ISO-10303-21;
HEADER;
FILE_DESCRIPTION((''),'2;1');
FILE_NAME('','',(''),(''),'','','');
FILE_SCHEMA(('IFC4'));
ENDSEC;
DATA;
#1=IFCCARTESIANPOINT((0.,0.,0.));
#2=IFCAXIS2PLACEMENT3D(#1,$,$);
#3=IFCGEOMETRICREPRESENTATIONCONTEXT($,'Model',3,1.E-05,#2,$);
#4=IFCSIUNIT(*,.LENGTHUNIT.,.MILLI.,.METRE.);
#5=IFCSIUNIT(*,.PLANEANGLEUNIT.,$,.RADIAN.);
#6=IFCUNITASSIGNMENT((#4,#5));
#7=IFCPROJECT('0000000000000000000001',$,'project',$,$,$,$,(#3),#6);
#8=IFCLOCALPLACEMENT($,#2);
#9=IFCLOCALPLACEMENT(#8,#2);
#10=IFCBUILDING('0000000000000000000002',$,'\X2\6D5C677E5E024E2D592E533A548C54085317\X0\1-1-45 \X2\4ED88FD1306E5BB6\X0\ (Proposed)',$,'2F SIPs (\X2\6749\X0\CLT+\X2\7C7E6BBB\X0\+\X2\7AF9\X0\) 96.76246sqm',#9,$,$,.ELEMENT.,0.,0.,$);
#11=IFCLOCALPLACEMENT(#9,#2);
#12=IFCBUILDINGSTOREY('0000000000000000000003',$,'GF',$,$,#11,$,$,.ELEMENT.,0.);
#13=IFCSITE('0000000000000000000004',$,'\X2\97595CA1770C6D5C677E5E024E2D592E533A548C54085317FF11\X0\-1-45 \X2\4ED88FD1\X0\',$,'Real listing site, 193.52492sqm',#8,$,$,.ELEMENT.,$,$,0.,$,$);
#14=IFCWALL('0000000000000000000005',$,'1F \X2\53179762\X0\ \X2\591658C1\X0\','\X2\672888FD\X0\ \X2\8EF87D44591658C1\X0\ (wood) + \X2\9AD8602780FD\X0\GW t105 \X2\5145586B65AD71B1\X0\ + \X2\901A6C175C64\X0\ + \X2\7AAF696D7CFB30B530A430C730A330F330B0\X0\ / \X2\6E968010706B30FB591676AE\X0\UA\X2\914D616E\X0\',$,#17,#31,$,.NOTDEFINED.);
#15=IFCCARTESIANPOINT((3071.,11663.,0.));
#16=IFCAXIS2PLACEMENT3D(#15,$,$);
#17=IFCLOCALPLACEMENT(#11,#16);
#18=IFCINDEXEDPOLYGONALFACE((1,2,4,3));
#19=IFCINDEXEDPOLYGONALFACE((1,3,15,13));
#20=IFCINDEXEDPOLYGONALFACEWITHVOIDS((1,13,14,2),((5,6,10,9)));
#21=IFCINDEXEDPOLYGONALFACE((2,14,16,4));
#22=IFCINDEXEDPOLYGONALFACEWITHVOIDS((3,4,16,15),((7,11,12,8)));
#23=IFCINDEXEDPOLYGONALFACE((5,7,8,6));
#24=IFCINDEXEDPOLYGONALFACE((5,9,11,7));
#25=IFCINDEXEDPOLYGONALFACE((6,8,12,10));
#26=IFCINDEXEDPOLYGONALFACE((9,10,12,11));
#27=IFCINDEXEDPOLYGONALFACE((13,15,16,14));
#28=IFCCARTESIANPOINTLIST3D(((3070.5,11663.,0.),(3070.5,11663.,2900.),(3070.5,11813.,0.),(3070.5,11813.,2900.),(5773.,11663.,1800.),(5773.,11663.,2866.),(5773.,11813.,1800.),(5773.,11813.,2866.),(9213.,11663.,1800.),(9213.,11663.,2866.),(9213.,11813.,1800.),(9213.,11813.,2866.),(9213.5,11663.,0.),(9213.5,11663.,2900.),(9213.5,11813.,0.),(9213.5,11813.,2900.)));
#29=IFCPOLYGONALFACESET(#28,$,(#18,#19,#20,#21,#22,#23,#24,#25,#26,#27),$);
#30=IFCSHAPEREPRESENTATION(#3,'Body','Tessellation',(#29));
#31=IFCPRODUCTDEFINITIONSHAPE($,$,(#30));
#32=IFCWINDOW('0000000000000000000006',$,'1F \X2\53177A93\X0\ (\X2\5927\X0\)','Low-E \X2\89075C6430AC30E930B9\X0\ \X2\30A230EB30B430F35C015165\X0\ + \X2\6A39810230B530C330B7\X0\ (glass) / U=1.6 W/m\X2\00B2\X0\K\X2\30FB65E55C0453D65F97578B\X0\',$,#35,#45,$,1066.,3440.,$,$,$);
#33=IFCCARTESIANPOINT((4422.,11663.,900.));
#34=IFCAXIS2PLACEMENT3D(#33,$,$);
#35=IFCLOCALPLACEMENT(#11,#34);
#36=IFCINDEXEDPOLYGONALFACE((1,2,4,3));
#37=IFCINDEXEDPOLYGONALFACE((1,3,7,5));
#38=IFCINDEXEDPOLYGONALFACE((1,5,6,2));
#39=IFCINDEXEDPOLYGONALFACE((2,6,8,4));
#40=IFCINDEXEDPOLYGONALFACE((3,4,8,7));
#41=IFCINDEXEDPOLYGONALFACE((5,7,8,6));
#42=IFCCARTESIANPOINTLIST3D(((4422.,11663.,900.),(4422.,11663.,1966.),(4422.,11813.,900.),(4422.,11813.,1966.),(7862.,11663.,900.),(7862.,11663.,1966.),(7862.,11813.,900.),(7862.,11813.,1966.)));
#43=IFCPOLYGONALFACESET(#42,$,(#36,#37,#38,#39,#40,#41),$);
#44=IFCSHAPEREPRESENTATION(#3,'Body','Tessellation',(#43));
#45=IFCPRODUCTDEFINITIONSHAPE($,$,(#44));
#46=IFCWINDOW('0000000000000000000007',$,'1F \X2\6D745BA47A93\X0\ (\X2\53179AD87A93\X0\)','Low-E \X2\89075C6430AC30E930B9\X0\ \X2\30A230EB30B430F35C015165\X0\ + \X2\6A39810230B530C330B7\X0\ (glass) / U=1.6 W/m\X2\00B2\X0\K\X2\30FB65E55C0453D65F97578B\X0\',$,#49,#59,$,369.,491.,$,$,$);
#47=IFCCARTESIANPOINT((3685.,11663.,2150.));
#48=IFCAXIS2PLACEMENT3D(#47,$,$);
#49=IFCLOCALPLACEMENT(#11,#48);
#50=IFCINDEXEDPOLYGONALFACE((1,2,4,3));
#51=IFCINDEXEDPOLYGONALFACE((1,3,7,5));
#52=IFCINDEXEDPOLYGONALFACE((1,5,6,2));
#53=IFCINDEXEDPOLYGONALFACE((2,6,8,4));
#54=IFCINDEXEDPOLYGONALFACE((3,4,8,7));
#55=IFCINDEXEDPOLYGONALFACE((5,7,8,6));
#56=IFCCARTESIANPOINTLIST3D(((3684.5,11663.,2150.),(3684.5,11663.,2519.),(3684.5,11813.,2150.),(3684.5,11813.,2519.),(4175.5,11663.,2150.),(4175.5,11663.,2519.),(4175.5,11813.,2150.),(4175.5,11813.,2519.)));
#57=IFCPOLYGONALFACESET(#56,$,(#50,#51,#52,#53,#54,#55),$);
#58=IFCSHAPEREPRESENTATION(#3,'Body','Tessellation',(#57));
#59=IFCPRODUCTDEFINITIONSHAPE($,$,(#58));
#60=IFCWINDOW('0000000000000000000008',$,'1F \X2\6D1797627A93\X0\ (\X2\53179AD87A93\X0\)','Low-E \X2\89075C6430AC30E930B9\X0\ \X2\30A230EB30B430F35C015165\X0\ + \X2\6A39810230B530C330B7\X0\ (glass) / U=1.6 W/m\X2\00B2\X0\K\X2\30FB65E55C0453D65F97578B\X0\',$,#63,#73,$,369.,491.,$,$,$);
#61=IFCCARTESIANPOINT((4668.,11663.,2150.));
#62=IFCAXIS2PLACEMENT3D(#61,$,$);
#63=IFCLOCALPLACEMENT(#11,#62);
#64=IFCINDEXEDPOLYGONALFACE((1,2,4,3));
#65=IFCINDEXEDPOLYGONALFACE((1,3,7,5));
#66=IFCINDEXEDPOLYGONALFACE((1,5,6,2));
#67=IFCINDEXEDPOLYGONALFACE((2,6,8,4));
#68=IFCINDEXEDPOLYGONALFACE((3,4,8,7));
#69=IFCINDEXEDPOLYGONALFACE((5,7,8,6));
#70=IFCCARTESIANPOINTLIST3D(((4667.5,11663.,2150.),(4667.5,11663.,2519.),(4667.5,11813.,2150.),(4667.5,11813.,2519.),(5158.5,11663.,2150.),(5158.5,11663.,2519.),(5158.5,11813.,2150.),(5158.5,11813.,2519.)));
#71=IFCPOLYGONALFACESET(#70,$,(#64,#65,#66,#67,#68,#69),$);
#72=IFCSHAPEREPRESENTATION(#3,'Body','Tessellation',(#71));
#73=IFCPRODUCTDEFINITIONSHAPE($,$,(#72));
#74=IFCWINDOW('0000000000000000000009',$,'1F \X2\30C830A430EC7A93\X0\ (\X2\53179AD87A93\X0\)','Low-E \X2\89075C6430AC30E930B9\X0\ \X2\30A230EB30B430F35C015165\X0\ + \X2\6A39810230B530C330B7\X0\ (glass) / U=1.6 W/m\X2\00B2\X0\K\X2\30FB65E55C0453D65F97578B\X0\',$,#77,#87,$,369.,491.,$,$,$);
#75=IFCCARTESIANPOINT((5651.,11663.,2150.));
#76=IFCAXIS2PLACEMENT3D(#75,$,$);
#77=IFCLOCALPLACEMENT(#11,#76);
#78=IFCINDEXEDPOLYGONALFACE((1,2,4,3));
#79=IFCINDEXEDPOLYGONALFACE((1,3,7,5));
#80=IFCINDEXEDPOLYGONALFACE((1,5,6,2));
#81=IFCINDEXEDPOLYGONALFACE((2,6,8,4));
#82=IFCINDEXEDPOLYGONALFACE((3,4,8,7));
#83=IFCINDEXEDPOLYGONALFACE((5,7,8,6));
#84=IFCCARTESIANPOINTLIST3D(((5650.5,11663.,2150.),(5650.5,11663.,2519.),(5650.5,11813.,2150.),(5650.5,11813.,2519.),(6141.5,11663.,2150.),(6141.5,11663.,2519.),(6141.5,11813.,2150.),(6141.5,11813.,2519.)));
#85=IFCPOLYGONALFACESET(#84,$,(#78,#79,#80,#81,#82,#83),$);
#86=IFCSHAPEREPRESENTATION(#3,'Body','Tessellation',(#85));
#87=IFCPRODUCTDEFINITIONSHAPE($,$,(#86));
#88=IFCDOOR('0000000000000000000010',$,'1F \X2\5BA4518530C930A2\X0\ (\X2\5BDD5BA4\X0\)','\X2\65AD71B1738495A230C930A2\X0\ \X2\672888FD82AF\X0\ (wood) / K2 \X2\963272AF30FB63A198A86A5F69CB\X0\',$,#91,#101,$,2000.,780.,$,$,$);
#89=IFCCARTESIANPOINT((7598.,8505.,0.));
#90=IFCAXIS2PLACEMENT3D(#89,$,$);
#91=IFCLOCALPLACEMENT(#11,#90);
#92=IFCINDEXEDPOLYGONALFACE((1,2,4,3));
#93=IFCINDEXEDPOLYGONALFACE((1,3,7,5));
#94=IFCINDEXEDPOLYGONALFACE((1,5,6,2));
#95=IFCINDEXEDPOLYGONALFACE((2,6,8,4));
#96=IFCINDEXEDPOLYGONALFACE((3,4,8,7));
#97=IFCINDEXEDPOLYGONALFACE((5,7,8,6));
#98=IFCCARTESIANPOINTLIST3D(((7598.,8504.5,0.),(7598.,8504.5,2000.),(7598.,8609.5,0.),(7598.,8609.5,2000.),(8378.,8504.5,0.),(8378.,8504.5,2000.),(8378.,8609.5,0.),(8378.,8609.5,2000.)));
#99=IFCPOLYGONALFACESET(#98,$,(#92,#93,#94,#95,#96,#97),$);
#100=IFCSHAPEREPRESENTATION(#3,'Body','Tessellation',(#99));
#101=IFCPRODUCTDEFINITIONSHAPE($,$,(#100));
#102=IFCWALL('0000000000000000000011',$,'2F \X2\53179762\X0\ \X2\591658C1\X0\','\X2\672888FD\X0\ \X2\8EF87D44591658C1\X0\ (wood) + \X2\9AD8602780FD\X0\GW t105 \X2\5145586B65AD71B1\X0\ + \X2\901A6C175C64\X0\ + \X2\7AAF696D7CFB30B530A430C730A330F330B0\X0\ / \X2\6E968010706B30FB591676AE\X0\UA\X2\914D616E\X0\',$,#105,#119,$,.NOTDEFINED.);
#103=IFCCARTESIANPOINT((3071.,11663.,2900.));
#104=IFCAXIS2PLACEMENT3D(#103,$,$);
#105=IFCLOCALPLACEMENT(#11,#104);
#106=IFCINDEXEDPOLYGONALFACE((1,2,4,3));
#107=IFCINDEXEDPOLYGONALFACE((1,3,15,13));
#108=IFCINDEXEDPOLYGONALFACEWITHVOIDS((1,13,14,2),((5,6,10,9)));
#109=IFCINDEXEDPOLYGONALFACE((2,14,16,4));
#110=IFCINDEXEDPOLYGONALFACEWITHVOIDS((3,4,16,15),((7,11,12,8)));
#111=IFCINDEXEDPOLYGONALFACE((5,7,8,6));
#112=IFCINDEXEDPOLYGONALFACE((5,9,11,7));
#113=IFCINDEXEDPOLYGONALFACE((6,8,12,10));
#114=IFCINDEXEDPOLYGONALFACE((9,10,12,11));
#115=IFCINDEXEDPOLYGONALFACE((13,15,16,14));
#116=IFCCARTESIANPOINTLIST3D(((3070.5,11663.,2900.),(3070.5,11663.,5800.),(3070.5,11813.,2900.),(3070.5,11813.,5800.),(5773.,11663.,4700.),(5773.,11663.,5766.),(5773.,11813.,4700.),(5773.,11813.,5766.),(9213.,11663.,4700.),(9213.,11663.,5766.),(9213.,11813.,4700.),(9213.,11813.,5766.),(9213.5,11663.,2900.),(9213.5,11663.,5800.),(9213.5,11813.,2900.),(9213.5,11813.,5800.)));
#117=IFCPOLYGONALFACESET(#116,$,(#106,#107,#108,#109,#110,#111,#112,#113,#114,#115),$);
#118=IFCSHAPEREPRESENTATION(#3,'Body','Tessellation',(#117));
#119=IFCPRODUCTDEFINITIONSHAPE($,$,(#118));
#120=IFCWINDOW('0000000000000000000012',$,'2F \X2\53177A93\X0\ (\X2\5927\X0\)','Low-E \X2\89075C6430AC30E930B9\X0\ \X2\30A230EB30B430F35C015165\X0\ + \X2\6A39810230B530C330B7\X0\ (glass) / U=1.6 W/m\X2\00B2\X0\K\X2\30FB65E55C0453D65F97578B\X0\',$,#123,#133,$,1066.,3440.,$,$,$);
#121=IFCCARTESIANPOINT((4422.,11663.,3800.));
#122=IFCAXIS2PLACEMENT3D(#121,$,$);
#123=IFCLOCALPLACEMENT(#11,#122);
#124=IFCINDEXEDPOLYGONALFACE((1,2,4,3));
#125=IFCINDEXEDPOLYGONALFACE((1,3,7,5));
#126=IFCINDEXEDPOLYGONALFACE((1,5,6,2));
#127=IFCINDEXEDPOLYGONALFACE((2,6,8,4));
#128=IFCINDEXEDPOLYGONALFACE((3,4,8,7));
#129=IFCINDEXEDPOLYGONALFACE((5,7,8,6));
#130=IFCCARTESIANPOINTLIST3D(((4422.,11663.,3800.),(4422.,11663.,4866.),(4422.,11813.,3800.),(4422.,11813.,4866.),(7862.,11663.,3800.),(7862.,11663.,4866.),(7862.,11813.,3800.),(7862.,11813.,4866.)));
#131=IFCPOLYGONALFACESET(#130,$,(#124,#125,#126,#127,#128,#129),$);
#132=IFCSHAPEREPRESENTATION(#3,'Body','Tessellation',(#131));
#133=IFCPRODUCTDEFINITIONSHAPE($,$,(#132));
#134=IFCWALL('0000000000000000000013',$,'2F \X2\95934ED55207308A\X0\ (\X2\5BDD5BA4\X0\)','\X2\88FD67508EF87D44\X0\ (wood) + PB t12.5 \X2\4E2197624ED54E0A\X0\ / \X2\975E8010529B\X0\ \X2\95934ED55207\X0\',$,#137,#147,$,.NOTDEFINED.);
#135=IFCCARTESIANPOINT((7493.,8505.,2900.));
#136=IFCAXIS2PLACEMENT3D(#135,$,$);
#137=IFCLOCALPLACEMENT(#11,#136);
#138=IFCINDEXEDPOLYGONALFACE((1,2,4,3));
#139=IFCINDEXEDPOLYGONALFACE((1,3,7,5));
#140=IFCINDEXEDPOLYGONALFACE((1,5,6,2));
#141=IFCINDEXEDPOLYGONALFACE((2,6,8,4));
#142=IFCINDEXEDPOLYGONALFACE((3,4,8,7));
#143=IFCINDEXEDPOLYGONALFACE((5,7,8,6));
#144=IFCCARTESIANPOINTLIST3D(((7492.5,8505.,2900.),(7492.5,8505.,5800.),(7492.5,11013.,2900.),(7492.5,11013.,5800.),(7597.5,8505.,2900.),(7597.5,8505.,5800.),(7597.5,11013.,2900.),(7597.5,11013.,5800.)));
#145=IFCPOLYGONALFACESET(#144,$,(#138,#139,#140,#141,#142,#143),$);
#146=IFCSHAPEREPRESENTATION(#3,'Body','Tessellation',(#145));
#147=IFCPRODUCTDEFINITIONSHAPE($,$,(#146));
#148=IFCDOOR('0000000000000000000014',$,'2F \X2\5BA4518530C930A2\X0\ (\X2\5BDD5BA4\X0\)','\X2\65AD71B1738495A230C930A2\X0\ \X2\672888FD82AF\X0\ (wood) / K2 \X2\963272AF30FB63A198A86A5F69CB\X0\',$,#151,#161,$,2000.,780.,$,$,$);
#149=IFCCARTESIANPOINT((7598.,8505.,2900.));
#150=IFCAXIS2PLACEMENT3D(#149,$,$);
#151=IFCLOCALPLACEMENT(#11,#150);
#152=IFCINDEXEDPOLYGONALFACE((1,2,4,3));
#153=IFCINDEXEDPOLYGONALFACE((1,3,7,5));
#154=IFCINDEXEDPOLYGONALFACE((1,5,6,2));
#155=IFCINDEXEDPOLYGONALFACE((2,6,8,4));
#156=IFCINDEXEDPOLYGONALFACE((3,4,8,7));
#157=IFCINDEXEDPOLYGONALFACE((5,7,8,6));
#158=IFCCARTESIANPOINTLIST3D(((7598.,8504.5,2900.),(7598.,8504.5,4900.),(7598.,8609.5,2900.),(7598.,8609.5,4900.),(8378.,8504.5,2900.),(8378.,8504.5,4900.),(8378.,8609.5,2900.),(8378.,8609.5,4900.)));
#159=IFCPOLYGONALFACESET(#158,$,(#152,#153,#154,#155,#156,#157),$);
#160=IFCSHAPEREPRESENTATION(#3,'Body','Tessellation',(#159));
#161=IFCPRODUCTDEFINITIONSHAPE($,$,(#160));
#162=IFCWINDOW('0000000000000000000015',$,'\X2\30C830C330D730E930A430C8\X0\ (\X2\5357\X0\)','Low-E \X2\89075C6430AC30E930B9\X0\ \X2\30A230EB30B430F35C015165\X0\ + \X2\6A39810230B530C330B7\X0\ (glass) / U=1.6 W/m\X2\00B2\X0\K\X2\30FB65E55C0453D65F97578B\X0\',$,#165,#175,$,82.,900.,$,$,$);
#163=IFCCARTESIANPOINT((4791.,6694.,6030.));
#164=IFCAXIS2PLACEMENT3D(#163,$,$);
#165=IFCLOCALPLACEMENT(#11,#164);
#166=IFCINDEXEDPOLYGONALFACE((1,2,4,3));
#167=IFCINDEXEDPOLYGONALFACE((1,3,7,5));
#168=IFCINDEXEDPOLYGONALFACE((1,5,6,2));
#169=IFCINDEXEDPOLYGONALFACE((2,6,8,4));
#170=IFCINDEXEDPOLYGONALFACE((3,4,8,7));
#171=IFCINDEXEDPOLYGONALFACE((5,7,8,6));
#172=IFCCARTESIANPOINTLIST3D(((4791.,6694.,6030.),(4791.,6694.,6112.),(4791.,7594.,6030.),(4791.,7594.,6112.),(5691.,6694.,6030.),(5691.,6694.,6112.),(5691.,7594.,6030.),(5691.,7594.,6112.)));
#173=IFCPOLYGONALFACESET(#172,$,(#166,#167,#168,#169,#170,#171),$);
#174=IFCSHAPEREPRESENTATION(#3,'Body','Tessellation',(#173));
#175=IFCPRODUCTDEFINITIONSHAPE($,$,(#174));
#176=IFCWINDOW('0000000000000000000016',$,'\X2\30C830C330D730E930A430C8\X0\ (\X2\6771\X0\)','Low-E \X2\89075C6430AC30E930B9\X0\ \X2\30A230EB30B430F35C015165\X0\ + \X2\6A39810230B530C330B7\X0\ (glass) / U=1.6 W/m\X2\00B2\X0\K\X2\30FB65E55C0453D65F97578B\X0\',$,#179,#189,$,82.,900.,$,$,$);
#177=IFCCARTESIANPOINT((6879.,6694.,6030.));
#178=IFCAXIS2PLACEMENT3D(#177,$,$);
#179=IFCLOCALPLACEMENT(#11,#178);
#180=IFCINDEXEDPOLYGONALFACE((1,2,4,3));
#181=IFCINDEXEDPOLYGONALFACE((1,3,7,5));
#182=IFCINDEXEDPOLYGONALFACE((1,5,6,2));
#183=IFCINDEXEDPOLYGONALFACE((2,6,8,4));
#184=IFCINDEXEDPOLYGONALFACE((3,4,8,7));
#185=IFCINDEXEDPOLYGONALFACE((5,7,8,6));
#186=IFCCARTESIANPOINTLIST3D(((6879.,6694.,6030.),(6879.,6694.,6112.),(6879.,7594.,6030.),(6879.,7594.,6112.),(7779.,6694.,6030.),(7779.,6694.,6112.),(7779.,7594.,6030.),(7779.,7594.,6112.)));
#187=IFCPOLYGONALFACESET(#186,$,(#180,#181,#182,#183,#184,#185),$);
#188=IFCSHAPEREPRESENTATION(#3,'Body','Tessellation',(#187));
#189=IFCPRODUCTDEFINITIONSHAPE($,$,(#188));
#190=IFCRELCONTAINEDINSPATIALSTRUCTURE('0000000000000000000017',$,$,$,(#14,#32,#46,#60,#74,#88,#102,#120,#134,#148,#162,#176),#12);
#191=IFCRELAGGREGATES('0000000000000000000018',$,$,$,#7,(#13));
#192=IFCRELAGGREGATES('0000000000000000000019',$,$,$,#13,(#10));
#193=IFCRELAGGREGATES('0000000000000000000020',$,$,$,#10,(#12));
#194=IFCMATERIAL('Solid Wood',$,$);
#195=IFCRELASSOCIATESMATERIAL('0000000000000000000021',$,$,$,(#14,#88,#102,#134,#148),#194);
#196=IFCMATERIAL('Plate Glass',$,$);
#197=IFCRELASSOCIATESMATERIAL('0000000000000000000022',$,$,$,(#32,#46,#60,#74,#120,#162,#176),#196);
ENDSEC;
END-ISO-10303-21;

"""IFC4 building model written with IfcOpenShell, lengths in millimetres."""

from ifc_helpers import new_model, si_unit, frame, frame_2d, origin, place, context, project, spatial, rectangle, extrude, material, element, fill, save


model = new_model("IFC4")

# Units and contexts
model_context = context("Model", 3, precision=1e-05, world=origin())
ifc_project = project(units=[si_unit("LENGTHUNIT", "METRE", prefix="MILLI"), si_unit("PLANEANGLEUNIT", "RADIAN")], contexts=[model_context])

# Site, building, storey
site_placement = place(None, origin())
site = spatial("IfcSite", under=ifc_project, at=site_placement, Name="静岡県浜松市中央区和合北１-1-45 付近", ObjectType="Real listing site, 193.52492sqm", CompositionType="ELEMENT", RefElevation=0.0)
building_placement = place(site_placement, origin())
building = spatial("IfcBuilding", under=site, at=building_placement, Name="浜松市中央区和合北1-1-45 付近の家 (Proposed)", ObjectType="2F SIPs (杉CLT+籾殻+竹) 96.76246sqm", CompositionType="ELEMENT", ElevationOfRefHeight=0.0, ElevationOfTerrain=0.0)
storey_placement = place(building_placement, origin())
storey = spatial("IfcBuildingStorey", under=building, at=storey_placement, Name="GF", CompositionType="ELEMENT", Elevation=0.0)

# Wall, openings, windows
ifc_material_1 = material(Name="Solid Wood")
wall_1_placement = place(storey_placement, frame((3071.0, 11663.0, 0.0)))
wall_1 = element("IfcWall", 1, at=wall_1_placement, inside=storey, material=ifc_material_1, Name="1F 北面 外壁", Description="木製 軸組外壁 (wood) + 高性能GW t105 充填断熱 + 通気層 + 窯業系サイディング / 準耐火・外皮UA配慮", PredefinedType="NOTDEFINED", context=model_context, shape_type="SweptSolid", body=[
    extrude(rectangle(XDim=6143.0, YDim=150.0, at=frame_2d((3071.0, 75.0))), frame((3071.0, 11663.0, 0.0)), (0.0, 0.0, 1.0), 2900.0),
])
opening_1_placement = place(storey_placement, frame((4422.0, 11663.0, 900.0)))
opening_1 = element("IfcOpeningElement", 2, at=opening_1_placement, cuts=wall_1, PredefinedType="NOTDEFINED", context=model_context, shape_type="SweptSolid", body=[
    extrude(rectangle(XDim=3440.0, YDim=150.0, at=frame_2d((1720.0, 75.0))), frame((4422.0, 11663.0, 900.0)), (0.0, 0.0, 1.0), 1066.0),
])
opening_2_placement = place(storey_placement, frame((3685.0, 11663.0, 2150.0)))
opening_2 = element("IfcOpeningElement", 3, at=opening_2_placement, cuts=wall_1, PredefinedType="NOTDEFINED", context=model_context, shape_type="SweptSolid", body=[
    extrude(rectangle(XDim=491.0, YDim=150.0, at=frame_2d((245.0, 75.0))), frame((3685.0, 11663.0, 2150.0)), (0.0, 0.0, 1.0), 369.0),
])
opening_3_placement = place(storey_placement, frame((4668.0, 11663.0, 2150.0)))
opening_3 = element("IfcOpeningElement", 4, at=opening_3_placement, cuts=wall_1, PredefinedType="NOTDEFINED", context=model_context, shape_type="SweptSolid", body=[
    extrude(rectangle(XDim=491.0, YDim=150.0, at=frame_2d((245.0, 75.0))), frame((4668.0, 11663.0, 2150.0)), (0.0, 0.0, 1.0), 369.0),
])
opening_4_placement = place(storey_placement, frame((5651.0, 11663.0, 2150.0)))
opening_4 = element("IfcOpeningElement", 5, at=opening_4_placement, cuts=wall_1, PredefinedType="NOTDEFINED", context=model_context, shape_type="SweptSolid", body=[
    extrude(rectangle(XDim=491.0, YDim=150.0, at=frame_2d((245.0, 75.0))), frame((5651.0, 11663.0, 2150.0)), (0.0, 0.0, 1.0), 369.0),
])
ifc_material_2 = material(Name="Plate Glass")
window_1_placement = place(storey_placement, frame((4422.0, 11663.0, 900.0)))
window_1 = element("IfcWindow", 6, at=window_1_placement, inside=storey, material=ifc_material_2, Name="1F 北窓 (大)", Description="Low-E 複層ガラス アルゴン封入 + 樹脂サッシ (glass) / U=1.6 W/m²K・日射取得型", OverallHeight=1066.0, OverallWidth=3440.0, context=model_context, shape_type="SweptSolid", body=[
    extrude(rectangle(XDim=3440.0, YDim=150.0, at=frame_2d((1720.0, 75.0))), frame((4422.0, 11663.0, 900.0)), (0.0, 0.0, 1.0), 1066.0),
])
fill(opening_1, window_1)
window_2_placement = place(storey_placement, frame((3685.0, 11663.0, 2150.0)))
window_2 = element("IfcWindow", 7, at=window_2_placement, inside=storey, material=ifc_material_2, Name="1F 浴室窓 (北高窓)", Description="Low-E 複層ガラス アルゴン封入 + 樹脂サッシ (glass) / U=1.6 W/m²K・日射取得型", OverallHeight=369.0, OverallWidth=491.0, context=model_context, shape_type="SweptSolid", body=[
    extrude(rectangle(XDim=491.0, YDim=150.0, at=frame_2d((245.0, 75.0))), frame((3685.0, 11663.0, 2150.0)), (0.0, 0.0, 1.0), 369.0),
])
fill(opening_2, window_2)
window_3_placement = place(storey_placement, frame((4668.0, 11663.0, 2150.0)))
window_3 = element("IfcWindow", 8, at=window_3_placement, inside=storey, material=ifc_material_2, Name="1F 洗面窓 (北高窓)", Description="Low-E 複層ガラス アルゴン封入 + 樹脂サッシ (glass) / U=1.6 W/m²K・日射取得型", OverallHeight=369.0, OverallWidth=491.0, context=model_context, shape_type="SweptSolid", body=[
    extrude(rectangle(XDim=491.0, YDim=150.0, at=frame_2d((245.0, 75.0))), frame((4668.0, 11663.0, 2150.0)), (0.0, 0.0, 1.0), 369.0),
])
fill(opening_3, window_3)
window_4_placement = place(storey_placement, frame((5651.0, 11663.0, 2150.0)))
window_4 = element("IfcWindow", 9, at=window_4_placement, inside=storey, material=ifc_material_2, Name="1F トイレ窓 (北高窓)", Description="Low-E 複層ガラス アルゴン封入 + 樹脂サッシ (glass) / U=1.6 W/m²K・日射取得型", OverallHeight=369.0, OverallWidth=491.0, context=model_context, shape_type="SweptSolid", body=[
    extrude(rectangle(XDim=491.0, YDim=150.0, at=frame_2d((245.0, 75.0))), frame((5651.0, 11663.0, 2150.0)), (0.0, 0.0, 1.0), 369.0),
])
fill(opening_4, window_4)

# Door
door_1_placement = place(storey_placement, frame((7598.0, 8505.0, 0.0)))
element("IfcDoor", 10, at=door_1_placement, inside=storey, material=ifc_material_1, Name="1F 室内ドア (寝室)", Description="断熱玄関ドア 木製芯 (wood) / K2 防犯・採風機構", OverallHeight=2000.0, OverallWidth=780.0, context=model_context, shape_type="SweptSolid", body=[
    extrude(rectangle(XDim=780.0, YDim=105.0, at=frame_2d((390.0, 52.0))), frame((7598.0, 8505.0, 0.0)), (0.0, 0.0, 1.0), 2000.0),
])

# Wall, opening, window
wall_2_placement = place(storey_placement, frame((3071.0, 11663.0, 2900.0)))
wall_2 = element("IfcWall", 11, at=wall_2_placement, inside=storey, material=ifc_material_1, Name="2F 北面 外壁", Description="木製 軸組外壁 (wood) + 高性能GW t105 充填断熱 + 通気層 + 窯業系サイディング / 準耐火・外皮UA配慮", PredefinedType="NOTDEFINED", context=model_context, shape_type="SweptSolid", body=[
    extrude(rectangle(XDim=6143.0, YDim=150.0, at=frame_2d((3071.0, 75.0))), frame((3071.0, 11663.0, 2900.0)), (0.0, 0.0, 1.0), 2900.0),
])
opening_5_placement = place(storey_placement, frame((4422.0, 11663.0, 3800.0)))
opening_5 = element("IfcOpeningElement", 12, at=opening_5_placement, cuts=wall_2, PredefinedType="NOTDEFINED", context=model_context, shape_type="SweptSolid", body=[
    extrude(rectangle(XDim=3440.0, YDim=150.0, at=frame_2d((1720.0, 75.0))), frame((4422.0, 11663.0, 3800.0)), (0.0, 0.0, 1.0), 1066.0),
])
window_5_placement = place(storey_placement, frame((4422.0, 11663.0, 3800.0)))
window_5 = element("IfcWindow", 13, at=window_5_placement, inside=storey, material=ifc_material_2, Name="2F 北窓 (大)", Description="Low-E 複層ガラス アルゴン封入 + 樹脂サッシ (glass) / U=1.6 W/m²K・日射取得型", OverallHeight=1066.0, OverallWidth=3440.0, context=model_context, shape_type="SweptSolid", body=[
    extrude(rectangle(XDim=3440.0, YDim=150.0, at=frame_2d((1720.0, 75.0))), frame((4422.0, 11663.0, 3800.0)), (0.0, 0.0, 1.0), 1066.0),
])
fill(opening_5, window_5)

# Wall
wall_3_placement = place(storey_placement, frame((7493.0, 8505.0, 2900.0)))
element("IfcWall", 14, at=wall_3_placement, inside=storey, material=ifc_material_1, Name="2F 間仕切り (寝室)", Description="製材軸組 (wood) + PB t12.5 両面仕上 / 非耐力 間仕切", PredefinedType="NOTDEFINED", context=model_context, shape_type="SweptSolid", body=[
    extrude(rectangle(XDim=105.0, YDim=2508.0, at=frame_2d((52.0, 1254.0))), frame((7493.0, 8505.0, 2900.0)), (0.0, 0.0, 1.0), 2900.0),
])

# Door
door_2_placement = place(storey_placement, frame((7598.0, 8505.0, 2900.0)))
element("IfcDoor", 15, at=door_2_placement, inside=storey, material=ifc_material_1, Name="2F 室内ドア (寝室)", Description="断熱玄関ドア 木製芯 (wood) / K2 防犯・採風機構", OverallHeight=2000.0, OverallWidth=780.0, context=model_context, shape_type="SweptSolid", body=[
    extrude(rectangle(XDim=780.0, YDim=105.0, at=frame_2d((390.0, 52.0))), frame((7598.0, 8505.0, 2900.0)), (0.0, 0.0, 1.0), 2000.0),
])

# Windows
window_6_placement = place(storey_placement, frame((4791.0, 6694.0, 6030.0)))
element("IfcWindow", 16, at=window_6_placement, inside=storey, material=ifc_material_2, Name="トップライト (南)", Description="Low-E 複層ガラス アルゴン封入 + 樹脂サッシ (glass) / U=1.6 W/m²K・日射取得型", OverallHeight=82.0, OverallWidth=900.0, context=model_context, shape_type="SweptSolid", body=[
    extrude(rectangle(XDim=900.0, YDim=900.0, at=frame_2d((450.0, 450.0))), frame((4791.0, 6694.0, 6030.0)), (0.0, 0.0, 1.0), 82.0),
])
window_7_placement = place(storey_placement, frame((6879.0, 6694.0, 6030.0)))
element("IfcWindow", 17, at=window_7_placement, inside=storey, material=ifc_material_2, Name="トップライト (東)", Description="Low-E 複層ガラス アルゴン封入 + 樹脂サッシ (glass) / U=1.6 W/m²K・日射取得型", OverallHeight=82.0, OverallWidth=900.0, context=model_context, shape_type="SweptSolid", body=[
    extrude(rectangle(XDim=900.0, YDim=900.0, at=frame_2d((450.0, 450.0))), frame((6879.0, 6694.0, 6030.0)), (0.0, 0.0, 1.0), 82.0),
])

save(model, "model.ifc")
